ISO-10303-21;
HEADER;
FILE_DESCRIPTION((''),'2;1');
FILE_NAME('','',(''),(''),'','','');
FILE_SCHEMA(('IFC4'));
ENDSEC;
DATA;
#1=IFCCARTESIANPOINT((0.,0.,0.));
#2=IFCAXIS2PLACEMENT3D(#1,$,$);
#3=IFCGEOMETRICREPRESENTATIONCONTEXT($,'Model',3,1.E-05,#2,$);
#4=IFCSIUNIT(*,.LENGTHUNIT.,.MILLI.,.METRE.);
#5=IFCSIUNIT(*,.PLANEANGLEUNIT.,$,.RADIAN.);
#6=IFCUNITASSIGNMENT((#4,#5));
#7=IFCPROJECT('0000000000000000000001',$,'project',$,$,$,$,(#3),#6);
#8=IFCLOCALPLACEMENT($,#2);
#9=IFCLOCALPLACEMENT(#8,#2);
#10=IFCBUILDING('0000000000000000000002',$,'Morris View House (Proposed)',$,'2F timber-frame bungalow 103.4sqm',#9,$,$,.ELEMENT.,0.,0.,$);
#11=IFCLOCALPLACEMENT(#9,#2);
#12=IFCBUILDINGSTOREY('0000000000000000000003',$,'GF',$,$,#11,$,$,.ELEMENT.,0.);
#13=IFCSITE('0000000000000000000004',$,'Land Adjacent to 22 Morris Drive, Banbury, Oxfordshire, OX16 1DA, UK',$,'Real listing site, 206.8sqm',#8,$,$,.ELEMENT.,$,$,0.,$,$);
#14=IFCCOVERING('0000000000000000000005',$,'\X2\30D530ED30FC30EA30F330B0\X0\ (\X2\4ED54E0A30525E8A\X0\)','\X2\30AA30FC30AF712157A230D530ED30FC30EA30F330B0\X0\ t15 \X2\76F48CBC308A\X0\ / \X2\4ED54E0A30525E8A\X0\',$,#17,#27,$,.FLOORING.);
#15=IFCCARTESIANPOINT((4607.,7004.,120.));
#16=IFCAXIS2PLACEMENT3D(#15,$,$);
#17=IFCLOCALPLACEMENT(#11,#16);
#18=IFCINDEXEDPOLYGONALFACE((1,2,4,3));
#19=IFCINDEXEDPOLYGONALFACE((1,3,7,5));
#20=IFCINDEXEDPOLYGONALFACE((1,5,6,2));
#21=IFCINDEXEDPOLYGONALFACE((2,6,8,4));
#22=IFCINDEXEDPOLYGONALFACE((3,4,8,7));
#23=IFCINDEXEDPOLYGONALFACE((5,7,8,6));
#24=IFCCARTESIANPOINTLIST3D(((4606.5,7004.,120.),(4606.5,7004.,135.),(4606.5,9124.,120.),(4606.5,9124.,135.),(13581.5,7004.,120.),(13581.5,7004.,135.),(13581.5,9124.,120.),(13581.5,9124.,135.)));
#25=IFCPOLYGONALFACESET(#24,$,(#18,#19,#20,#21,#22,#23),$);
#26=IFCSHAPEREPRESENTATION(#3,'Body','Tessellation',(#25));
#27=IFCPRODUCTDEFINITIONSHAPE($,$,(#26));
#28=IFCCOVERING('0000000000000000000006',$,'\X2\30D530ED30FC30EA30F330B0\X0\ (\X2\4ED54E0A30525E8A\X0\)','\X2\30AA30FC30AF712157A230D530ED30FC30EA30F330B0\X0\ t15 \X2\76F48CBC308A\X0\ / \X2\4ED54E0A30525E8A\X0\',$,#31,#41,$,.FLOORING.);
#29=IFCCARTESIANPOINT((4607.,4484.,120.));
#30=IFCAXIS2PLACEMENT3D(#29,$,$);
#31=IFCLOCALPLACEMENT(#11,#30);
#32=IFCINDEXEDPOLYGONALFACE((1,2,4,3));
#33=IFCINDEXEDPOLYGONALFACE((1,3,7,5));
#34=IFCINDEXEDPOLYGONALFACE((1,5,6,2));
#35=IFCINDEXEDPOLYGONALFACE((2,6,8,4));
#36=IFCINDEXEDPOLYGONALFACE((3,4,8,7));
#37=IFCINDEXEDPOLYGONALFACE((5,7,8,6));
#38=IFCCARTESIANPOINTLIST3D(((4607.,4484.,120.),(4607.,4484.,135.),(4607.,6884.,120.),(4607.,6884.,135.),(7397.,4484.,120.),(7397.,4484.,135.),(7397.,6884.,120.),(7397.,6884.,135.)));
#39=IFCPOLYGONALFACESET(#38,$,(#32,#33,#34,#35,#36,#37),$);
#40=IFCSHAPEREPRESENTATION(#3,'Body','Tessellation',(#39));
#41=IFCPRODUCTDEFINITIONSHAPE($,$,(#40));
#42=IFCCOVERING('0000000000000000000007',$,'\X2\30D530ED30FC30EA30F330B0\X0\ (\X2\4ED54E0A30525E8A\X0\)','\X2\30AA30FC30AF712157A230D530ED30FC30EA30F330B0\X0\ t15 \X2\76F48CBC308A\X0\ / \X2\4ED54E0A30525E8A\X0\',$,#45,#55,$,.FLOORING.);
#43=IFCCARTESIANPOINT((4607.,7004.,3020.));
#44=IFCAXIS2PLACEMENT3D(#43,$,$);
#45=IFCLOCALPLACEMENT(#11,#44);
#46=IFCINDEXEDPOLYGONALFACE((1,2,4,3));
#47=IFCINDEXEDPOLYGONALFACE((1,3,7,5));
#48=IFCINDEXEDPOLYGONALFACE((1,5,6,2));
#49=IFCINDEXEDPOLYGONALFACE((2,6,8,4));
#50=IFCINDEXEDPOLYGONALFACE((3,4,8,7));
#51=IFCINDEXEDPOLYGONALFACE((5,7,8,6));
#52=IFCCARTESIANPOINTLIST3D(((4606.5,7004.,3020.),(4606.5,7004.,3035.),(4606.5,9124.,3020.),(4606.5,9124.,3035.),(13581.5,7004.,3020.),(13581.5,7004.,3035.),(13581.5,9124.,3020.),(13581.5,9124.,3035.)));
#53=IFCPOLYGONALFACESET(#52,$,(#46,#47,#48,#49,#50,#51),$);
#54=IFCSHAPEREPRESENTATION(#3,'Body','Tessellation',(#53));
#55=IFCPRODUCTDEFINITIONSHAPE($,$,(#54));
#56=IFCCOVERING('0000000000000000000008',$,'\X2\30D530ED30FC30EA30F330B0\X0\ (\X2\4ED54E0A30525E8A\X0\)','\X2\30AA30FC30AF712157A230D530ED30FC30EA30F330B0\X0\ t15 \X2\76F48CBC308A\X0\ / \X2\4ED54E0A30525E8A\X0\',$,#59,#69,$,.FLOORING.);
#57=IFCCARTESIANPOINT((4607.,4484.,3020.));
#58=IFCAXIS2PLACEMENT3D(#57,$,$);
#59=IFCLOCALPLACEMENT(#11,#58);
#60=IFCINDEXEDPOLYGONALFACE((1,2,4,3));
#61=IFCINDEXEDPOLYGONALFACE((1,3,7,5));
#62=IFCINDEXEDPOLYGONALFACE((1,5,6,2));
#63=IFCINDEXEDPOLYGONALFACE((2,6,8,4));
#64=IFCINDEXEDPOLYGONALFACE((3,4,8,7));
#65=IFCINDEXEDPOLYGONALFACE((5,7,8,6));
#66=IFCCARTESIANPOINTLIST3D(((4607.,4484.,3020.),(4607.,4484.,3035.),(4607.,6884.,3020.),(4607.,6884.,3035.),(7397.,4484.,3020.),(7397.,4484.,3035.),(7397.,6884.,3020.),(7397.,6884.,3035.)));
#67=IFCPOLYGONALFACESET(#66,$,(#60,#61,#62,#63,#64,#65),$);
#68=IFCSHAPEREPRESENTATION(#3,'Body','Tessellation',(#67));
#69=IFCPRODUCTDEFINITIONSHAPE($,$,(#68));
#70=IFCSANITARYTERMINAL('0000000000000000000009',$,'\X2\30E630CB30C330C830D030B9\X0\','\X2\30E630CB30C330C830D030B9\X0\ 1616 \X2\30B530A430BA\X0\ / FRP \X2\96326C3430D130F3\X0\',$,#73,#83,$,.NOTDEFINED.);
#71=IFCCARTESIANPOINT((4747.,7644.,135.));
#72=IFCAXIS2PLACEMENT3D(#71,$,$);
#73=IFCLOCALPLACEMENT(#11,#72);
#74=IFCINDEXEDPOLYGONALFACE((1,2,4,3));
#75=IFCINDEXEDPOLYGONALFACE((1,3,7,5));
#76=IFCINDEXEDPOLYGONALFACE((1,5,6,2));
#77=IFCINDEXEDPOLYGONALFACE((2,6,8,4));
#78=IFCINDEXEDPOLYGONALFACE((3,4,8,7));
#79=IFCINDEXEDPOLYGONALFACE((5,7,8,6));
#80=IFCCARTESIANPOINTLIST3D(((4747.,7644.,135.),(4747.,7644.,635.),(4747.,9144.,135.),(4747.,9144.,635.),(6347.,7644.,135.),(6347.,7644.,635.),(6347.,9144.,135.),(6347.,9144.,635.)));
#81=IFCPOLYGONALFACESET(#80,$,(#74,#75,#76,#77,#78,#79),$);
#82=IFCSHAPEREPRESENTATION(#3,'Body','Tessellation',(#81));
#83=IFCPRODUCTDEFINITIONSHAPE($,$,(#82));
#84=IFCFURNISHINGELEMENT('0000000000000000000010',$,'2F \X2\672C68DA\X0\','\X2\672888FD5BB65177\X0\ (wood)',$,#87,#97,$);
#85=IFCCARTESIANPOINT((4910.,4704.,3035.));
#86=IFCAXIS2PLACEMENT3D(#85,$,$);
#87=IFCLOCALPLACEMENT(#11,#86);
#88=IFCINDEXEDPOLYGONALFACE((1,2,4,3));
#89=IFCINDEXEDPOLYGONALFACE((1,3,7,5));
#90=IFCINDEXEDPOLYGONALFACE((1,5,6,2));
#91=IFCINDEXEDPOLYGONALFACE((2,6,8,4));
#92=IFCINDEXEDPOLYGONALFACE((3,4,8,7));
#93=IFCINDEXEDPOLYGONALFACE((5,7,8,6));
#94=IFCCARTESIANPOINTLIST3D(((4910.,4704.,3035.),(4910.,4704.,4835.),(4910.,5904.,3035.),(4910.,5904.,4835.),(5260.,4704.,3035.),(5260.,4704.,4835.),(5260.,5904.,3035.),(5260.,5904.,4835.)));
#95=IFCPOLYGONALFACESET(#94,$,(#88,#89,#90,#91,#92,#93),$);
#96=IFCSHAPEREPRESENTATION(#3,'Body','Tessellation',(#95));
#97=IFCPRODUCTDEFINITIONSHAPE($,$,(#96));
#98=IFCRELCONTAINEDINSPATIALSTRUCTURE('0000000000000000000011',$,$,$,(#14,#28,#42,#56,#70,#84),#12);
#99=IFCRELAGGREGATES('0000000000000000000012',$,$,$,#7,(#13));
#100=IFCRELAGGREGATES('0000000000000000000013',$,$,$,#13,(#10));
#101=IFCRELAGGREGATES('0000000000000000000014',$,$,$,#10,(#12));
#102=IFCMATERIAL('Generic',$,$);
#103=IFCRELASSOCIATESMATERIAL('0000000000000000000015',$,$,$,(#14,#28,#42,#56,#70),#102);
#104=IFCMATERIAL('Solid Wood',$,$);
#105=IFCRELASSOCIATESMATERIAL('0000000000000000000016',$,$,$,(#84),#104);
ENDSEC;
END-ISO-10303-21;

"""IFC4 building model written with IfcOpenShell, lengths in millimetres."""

from ifc_helpers import new_model, si_unit, frame, frame_2d, origin, place, context, project, spatial, rectangle, extrude, material, element, save


model = new_model("IFC4")

# Units and contexts
model_context = context("Model", 3, precision=1e-05, world=origin())
ifc_project = project(units=[si_unit("LENGTHUNIT", "METRE", prefix="MILLI"), si_unit("PLANEANGLEUNIT", "RADIAN")], contexts=[model_context])

# Site, building, storey
site_placement = place(None, origin())
site = spatial("IfcSite", under=ifc_project, at=site_placement, Name="Land Adjacent to 22 Morris Drive, Banbury, Oxfordshire, OX16 1DA, UK", ObjectType="Real listing site, 206.8sqm", CompositionType="ELEMENT", RefElevation=0.0)
building_placement = place(site_placement, origin())
building = spatial("IfcBuilding", under=site, at=building_placement, Name="Morris View House (Proposed)", ObjectType="2F timber-frame bungalow 103.4sqm", CompositionType="ELEMENT", ElevationOfRefHeight=0.0, ElevationOfTerrain=0.0)
storey_placement = place(building_placement, origin())
storey = spatial("IfcBuildingStorey", under=building, at=storey_placement, Name="GF", CompositionType="ELEMENT", Elevation=0.0)

# Shared definitions
ifc_material_1 = material(Name="Solid Wood")

# Coverings
ifc_material_2 = material(Name="Generic")
covering_1_placement = place(storey_placement, frame((4607.0, 7004.0, 120.0)))
element("IfcCovering", 1, at=covering_1_placement, inside=storey, material=ifc_material_2, Name="フローリング (仕上げ床)", Description="オーク無垢フローリング t15 直貼り / 仕上げ床", PredefinedType="FLOORING", context=model_context, shape_type="SweptSolid", body=[
    extrude(rectangle(XDim=8975.0, YDim=2120.0, at=frame_2d((4487.0, 1060.0))), frame((4607.0, 7004.0, 120.0)), (0.0, 0.0, 1.0), 15.0),
])
covering_2_placement = place(storey_placement, frame((4607.0, 4484.0, 120.0)))
element("IfcCovering", 2, at=covering_2_placement, inside=storey, material=ifc_material_2, Name="フローリング (仕上げ床)", Description="オーク無垢フローリング t15 直貼り / 仕上げ床", PredefinedType="FLOORING", context=model_context, shape_type="SweptSolid", body=[
    extrude(rectangle(XDim=2790.0, YDim=2400.0, at=frame_2d((1395.0, 1200.0))), frame((4607.0, 4484.0, 120.0)), (0.0, 0.0, 1.0), 15.0),
])
covering_3_placement = place(storey_placement, frame((4607.0, 7004.0, 3020.0)))
element("IfcCovering", 3, at=covering_3_placement, inside=storey, material=ifc_material_2, Name="フローリング (仕上げ床)", Description="オーク無垢フローリング t15 直貼り / 仕上げ床", PredefinedType="FLOORING", context=model_context, shape_type="SweptSolid", body=[
    extrude(rectangle(XDim=8975.0, YDim=2120.0, at=frame_2d((4487.0, 1060.0))), frame((4607.0, 7004.0, 3020.0)), (0.0, 0.0, 1.0), 15.0),
])
covering_4_placement = place(storey_placement, frame((4607.0, 4484.0, 3020.0)))
element("IfcCovering", 4, at=covering_4_placement, inside=storey, material=ifc_material_2, Name="フローリング (仕上げ床)", Description="オーク無垢フローリング t15 直貼り / 仕上げ床", PredefinedType="FLOORING", context=model_context, shape_type="SweptSolid", body=[
    extrude(rectangle(XDim=2790.0, YDim=2400.0, at=frame_2d((1395.0, 1200.0))), frame((4607.0, 4484.0, 3020.0)), (0.0, 0.0, 1.0), 15.0),
])

# Sanitary terminal
sanitary_terminal_placement = place(storey_placement, frame((4747.0, 7644.0, 135.0)))
element("IfcSanitaryTerminal", 5, at=sanitary_terminal_placement, inside=storey, material=ifc_material_2, Name="ユニットバス", Description="ユニットバス 1616 サイズ / FRP 防水パン", PredefinedType="NOTDEFINED", context=model_context, shape_type="SweptSolid", body=[
    extrude(rectangle(XDim=1600.0, YDim=1500.0, at=frame_2d((800.0, 750.0))), frame((4747.0, 7644.0, 135.0)), (0.0, 0.0, 1.0), 500.0),
])

# Furnishing element
furnishing_placement = place(storey_placement, frame((4910.0, 4704.0, 3035.0)))
element("IfcFurnishingElement", 6, at=furnishing_placement, inside=storey, material=ifc_material_1, Name="2F 本棚", Description="木製家具 (wood)", context=model_context, shape_type="SweptSolid", body=[
    extrude(rectangle(XDim=350.0, YDim=1200.0, at=frame_2d((175.0, 600.0))), frame((4910.0, 4704.0, 3035.0)), (0.0, 0.0, 1.0), 1800.0),
])

save(model, "model.ifc")
